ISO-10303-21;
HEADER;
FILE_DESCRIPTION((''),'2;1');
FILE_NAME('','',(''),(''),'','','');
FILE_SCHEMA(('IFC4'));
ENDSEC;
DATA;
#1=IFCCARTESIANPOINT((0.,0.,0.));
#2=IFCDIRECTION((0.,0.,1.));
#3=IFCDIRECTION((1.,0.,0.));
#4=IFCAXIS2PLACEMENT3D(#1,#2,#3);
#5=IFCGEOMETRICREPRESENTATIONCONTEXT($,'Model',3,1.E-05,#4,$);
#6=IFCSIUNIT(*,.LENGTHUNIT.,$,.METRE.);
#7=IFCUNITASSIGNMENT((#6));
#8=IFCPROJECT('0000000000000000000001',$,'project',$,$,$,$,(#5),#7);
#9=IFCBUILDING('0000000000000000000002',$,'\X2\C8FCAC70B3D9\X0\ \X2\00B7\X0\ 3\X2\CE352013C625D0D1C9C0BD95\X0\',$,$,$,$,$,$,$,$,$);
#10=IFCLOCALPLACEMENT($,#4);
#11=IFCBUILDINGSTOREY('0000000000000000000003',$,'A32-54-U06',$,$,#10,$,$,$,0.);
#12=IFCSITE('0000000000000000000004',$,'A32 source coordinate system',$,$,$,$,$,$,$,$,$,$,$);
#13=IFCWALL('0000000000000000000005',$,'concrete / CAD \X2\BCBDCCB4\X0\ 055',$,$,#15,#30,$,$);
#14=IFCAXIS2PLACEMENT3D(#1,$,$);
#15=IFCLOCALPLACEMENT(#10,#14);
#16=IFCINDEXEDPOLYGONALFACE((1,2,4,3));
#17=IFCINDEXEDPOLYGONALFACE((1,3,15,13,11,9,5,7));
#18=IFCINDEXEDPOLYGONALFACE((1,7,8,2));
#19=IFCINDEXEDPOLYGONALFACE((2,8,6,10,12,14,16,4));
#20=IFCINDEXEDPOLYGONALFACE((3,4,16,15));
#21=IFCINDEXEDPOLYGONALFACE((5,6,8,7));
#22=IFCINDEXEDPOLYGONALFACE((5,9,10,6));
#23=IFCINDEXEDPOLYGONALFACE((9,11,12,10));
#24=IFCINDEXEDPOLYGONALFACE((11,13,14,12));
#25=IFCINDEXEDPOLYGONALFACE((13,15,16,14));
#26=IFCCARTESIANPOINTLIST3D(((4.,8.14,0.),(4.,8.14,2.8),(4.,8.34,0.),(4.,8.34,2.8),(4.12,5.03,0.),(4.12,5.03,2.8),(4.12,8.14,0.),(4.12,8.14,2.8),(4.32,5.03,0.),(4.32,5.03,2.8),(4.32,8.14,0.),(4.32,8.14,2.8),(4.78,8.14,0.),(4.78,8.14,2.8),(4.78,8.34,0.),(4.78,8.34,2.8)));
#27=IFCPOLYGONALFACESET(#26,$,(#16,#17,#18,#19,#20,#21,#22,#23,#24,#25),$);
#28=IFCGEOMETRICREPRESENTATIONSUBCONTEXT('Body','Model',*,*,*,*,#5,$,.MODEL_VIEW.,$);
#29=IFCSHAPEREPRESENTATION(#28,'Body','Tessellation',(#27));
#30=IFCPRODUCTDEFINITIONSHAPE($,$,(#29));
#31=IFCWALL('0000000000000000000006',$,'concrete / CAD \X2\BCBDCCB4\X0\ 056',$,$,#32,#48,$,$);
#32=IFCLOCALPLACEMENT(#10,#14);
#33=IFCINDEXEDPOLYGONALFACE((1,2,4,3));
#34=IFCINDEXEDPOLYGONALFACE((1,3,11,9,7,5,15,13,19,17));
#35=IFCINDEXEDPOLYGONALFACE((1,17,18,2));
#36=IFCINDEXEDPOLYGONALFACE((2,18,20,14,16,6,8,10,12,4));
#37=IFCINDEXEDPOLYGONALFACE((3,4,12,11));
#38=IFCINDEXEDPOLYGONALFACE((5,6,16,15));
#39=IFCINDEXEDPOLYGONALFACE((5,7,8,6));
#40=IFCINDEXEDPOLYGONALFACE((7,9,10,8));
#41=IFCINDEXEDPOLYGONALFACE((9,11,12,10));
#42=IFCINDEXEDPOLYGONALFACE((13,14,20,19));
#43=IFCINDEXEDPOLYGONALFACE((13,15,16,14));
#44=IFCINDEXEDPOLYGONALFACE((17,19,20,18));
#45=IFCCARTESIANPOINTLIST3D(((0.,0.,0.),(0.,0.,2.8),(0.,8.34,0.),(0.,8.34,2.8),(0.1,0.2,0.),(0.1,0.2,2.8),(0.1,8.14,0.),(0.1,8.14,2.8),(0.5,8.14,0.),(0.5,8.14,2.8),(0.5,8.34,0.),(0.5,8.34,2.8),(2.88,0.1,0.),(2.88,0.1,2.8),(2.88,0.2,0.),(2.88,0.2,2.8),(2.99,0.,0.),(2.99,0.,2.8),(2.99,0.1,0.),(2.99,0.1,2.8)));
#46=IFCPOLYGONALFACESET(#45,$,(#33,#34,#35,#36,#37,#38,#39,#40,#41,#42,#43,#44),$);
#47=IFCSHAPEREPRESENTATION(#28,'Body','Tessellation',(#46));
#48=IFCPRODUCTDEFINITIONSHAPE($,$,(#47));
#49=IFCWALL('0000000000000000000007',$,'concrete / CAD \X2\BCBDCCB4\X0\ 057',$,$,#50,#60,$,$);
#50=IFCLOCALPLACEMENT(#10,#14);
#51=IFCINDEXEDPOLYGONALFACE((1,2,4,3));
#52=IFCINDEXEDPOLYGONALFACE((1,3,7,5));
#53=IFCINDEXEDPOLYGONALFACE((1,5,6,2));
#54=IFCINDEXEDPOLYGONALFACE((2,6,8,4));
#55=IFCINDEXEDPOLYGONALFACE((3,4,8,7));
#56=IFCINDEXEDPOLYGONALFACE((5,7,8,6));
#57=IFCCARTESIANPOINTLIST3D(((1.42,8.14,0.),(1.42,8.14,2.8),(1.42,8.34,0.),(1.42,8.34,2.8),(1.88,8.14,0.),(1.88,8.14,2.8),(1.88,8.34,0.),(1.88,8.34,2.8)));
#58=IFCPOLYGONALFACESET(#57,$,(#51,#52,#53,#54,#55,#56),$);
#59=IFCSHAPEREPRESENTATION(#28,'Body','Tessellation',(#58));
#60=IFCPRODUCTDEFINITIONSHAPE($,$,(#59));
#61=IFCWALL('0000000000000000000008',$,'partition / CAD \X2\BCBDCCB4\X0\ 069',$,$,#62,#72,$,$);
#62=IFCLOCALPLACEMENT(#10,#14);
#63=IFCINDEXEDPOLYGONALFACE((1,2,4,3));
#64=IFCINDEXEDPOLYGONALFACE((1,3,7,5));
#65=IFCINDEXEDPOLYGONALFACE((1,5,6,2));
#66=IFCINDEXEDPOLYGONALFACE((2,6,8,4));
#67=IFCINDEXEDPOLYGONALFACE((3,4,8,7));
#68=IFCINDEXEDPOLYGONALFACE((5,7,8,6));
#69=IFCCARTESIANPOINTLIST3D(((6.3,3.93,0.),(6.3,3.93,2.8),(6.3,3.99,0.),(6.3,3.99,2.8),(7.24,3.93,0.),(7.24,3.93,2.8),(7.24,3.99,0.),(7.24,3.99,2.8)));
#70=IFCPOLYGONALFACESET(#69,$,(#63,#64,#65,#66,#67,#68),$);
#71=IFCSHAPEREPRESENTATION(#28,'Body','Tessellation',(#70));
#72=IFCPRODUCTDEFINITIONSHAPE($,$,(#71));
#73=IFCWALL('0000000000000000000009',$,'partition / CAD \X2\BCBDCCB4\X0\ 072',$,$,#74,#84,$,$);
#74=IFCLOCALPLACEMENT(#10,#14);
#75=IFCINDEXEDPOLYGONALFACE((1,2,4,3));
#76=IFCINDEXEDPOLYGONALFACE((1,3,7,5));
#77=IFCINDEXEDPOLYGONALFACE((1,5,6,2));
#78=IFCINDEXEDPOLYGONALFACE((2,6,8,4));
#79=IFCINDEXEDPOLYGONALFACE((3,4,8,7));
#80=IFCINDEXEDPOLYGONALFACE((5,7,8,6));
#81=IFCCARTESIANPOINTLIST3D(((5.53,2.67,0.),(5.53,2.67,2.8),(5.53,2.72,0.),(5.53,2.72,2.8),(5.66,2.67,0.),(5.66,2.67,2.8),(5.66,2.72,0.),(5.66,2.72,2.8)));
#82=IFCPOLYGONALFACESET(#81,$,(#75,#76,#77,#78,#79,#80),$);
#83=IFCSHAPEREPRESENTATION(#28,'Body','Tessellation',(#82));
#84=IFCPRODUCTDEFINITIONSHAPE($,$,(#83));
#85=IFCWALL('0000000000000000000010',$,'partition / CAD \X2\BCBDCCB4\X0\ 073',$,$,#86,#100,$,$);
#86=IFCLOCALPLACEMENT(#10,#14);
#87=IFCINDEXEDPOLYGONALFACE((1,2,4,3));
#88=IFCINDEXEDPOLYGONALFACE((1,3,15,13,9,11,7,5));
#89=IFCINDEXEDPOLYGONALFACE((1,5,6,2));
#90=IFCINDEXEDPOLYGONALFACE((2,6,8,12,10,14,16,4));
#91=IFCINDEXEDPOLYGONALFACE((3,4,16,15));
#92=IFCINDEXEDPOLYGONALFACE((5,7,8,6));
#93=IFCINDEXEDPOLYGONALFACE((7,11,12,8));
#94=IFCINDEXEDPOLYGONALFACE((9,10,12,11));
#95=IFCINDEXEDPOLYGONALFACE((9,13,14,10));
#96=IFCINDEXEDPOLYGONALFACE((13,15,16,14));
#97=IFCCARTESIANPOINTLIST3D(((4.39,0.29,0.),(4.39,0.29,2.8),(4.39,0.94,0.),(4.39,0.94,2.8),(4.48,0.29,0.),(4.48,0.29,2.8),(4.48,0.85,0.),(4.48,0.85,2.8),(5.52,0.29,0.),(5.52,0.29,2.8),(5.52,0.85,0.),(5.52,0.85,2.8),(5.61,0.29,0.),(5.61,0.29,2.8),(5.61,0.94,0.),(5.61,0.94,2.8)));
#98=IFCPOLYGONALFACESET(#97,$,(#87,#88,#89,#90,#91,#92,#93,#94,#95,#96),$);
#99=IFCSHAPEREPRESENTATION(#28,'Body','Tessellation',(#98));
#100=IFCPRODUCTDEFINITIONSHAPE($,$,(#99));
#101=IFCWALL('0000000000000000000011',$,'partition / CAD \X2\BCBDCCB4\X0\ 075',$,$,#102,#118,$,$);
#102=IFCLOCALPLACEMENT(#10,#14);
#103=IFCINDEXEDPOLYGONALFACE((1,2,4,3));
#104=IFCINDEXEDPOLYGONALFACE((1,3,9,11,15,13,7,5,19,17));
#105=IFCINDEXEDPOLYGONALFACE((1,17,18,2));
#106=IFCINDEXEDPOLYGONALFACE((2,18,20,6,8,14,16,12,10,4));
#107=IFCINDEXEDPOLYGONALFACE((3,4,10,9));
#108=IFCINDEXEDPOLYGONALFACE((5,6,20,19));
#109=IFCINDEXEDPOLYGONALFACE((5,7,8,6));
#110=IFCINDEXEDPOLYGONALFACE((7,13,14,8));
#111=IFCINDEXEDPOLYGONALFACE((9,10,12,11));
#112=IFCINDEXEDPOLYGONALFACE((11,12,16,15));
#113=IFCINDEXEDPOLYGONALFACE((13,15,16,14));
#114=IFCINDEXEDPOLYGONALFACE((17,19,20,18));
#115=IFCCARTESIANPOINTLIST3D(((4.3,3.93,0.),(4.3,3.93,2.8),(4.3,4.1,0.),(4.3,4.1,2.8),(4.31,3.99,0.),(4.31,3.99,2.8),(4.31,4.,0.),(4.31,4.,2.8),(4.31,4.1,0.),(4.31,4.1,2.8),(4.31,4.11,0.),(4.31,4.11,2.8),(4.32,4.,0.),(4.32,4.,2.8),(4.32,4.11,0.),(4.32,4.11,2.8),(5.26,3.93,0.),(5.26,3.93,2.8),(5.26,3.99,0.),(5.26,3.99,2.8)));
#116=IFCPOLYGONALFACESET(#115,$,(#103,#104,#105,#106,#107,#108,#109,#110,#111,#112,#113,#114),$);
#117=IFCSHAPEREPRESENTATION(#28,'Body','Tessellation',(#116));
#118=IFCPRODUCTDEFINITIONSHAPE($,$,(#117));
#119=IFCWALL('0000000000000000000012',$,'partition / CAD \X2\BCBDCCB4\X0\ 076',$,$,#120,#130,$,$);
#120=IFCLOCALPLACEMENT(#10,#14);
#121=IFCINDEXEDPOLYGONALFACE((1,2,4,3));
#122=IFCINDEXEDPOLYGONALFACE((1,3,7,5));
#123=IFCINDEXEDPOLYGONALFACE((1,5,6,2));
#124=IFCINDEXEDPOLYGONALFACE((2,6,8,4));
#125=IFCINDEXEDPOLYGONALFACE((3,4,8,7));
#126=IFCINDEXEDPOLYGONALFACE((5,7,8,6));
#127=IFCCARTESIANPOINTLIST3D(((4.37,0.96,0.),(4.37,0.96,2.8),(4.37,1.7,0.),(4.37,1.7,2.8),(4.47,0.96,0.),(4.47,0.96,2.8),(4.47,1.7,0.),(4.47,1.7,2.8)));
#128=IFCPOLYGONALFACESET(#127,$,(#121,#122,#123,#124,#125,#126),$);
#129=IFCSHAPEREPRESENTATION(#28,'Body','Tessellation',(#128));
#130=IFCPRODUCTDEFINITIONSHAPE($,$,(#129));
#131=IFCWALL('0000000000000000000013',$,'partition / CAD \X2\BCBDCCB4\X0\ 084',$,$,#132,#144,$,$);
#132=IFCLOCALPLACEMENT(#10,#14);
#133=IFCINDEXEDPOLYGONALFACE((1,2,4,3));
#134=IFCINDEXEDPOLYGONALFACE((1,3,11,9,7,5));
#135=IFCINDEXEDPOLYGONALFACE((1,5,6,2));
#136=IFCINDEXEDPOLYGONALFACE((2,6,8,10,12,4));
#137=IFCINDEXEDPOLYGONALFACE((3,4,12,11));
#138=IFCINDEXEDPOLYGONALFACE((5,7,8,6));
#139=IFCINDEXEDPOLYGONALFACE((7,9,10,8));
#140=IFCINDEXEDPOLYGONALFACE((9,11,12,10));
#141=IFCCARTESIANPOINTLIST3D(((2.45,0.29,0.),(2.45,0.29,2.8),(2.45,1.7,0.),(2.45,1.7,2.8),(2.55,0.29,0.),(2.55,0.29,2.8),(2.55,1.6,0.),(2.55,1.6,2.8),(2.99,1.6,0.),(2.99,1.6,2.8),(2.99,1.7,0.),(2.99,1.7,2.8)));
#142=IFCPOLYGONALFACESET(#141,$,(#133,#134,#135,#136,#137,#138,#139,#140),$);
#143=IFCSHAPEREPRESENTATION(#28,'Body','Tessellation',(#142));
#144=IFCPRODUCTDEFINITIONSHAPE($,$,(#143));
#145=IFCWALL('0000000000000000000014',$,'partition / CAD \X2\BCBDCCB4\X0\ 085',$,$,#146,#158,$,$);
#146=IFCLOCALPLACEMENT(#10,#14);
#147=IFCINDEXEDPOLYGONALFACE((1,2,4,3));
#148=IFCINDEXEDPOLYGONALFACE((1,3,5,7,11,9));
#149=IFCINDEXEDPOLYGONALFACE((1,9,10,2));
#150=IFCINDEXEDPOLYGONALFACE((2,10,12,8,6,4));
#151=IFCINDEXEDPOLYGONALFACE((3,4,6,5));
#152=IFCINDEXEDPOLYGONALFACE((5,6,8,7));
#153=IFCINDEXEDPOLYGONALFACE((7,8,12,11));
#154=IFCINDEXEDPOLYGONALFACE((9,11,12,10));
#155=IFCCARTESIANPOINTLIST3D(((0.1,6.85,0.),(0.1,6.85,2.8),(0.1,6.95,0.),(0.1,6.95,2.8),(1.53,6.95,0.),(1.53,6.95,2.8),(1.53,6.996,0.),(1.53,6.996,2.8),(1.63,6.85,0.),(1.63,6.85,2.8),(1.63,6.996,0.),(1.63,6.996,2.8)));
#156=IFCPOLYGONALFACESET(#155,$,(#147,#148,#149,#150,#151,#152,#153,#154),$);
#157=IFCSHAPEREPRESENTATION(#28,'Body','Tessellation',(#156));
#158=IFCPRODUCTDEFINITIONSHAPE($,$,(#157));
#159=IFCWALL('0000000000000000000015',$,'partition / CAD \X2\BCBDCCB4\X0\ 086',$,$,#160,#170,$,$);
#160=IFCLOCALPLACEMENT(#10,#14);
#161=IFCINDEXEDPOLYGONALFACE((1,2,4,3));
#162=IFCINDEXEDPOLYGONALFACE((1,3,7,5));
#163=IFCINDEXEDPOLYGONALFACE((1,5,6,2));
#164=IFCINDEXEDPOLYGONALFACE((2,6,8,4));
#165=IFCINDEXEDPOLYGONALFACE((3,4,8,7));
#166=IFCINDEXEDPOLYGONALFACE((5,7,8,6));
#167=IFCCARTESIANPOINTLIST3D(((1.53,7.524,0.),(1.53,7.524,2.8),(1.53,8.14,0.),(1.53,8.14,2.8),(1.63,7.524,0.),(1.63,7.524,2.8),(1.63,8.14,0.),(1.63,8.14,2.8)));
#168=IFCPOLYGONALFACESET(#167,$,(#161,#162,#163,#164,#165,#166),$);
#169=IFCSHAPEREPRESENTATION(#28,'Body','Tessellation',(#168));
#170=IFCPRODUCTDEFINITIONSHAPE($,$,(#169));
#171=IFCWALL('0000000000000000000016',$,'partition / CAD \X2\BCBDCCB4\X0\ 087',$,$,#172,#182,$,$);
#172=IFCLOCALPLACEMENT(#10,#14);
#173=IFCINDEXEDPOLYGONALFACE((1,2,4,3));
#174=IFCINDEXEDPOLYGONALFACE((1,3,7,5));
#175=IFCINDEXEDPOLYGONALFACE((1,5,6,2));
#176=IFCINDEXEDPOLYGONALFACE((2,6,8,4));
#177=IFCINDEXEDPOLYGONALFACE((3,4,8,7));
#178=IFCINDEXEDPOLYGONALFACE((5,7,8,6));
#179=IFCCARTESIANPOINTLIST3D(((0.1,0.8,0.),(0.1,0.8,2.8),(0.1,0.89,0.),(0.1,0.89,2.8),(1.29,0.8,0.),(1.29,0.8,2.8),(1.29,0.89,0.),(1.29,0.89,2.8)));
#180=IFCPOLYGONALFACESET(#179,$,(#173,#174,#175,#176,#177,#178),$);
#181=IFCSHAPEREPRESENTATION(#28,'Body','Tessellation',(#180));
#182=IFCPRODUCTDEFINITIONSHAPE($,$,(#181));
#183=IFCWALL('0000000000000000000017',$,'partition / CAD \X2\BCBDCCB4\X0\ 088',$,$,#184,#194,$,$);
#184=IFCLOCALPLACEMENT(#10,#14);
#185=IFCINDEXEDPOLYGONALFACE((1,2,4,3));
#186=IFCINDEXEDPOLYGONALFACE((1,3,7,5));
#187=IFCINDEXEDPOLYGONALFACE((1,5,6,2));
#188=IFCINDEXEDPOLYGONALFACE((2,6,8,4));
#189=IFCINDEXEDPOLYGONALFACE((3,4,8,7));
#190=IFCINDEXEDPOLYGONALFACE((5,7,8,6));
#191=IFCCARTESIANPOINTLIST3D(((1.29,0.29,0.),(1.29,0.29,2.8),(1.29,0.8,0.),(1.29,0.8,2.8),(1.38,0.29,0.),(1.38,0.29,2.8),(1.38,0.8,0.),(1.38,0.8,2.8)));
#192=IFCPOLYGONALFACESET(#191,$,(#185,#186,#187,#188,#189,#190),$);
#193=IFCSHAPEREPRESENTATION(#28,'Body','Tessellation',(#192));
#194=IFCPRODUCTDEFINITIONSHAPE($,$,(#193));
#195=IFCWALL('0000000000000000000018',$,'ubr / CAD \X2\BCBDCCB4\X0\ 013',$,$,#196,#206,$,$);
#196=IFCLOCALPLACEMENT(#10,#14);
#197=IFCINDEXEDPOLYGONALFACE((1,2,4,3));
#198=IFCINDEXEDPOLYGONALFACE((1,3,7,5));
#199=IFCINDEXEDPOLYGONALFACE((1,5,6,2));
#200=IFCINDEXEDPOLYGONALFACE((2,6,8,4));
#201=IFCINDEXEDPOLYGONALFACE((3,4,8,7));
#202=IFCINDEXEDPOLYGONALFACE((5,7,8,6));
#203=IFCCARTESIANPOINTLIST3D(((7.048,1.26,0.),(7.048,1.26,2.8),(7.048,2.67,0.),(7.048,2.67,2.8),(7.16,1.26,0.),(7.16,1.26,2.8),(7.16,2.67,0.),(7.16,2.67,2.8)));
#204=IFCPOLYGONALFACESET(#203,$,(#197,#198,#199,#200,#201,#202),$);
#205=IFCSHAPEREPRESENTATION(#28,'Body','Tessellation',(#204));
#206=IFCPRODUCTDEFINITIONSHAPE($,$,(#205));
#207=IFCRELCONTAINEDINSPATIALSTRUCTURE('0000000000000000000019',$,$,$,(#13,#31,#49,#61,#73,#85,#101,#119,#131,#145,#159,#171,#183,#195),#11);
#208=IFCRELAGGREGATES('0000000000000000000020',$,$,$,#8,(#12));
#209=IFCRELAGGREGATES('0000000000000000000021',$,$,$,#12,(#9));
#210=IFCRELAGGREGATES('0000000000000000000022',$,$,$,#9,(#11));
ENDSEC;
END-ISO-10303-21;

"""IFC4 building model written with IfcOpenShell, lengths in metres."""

from ifc_helpers import new_model, si_unit, origin, origin_with_axes, place, context, subcontext, project, spatial, polyline, outline, extrude, element, save


model = new_model("IFC4")

# Units and contexts
model_context = context("Model", 3, precision=1e-05, world=origin_with_axes())
body_context = subcontext(model_context, "Body", "Model", "MODEL_VIEW")
ifc_project = project(units=[si_unit("LENGTHUNIT", "METRE")], contexts=[model_context])

# Site, building, storey
site = spatial("IfcSite", under=ifc_project, Name="A32 source coordinate system")
building = spatial("IfcBuilding", under=site, Name="주거동 · 3층–옥탑지붕")
storey_placement = place(None, origin_with_axes())
storey = spatial("IfcBuildingStorey", under=building, at=storey_placement, Name="A32-54-U06", Elevation=0.0)

# Walls
wall_1_placement = place(storey_placement, origin_with_axes())
element("IfcWall", 1, at=wall_1_placement, inside=storey, Name="concrete / CAD 벽체 055", context=body_context, shape_type="SweptSolid", body=[
    extrude(outline(polyline([(4.32, 5.03), (4.12, 5.03), (4.12, 8.14), (4.0, 8.14), (4.0, 8.34), (4.78, 8.34), (4.78, 8.14), (4.32, 8.14), (4.32, 5.03)])), origin(), (0.0, 0.0, 1.0), 2.8),
])
wall_2_placement = place(storey_placement, origin_with_axes())
element("IfcWall", 2, at=wall_2_placement, inside=storey, Name="concrete / CAD 벽체 056", context=body_context, shape_type="SweptSolid", body=[
    extrude(outline(polyline([(0.1, 8.14), (0.1, 0.2), (2.88, 0.2), (2.88, 0.1), (2.99, 0.1), (2.99, 0.0), (0.0, 0.0), (0.0, 8.34), (-0.35, 8.34), (-0.35, 8.34), (0.5, 8.34), (0.5, 8.14), (0.1, 8.14)])), origin(), (0.0, 0.0, 1.0), 2.8),
])
wall_3_placement = place(storey_placement, origin_with_axes())
element("IfcWall", 3, at=wall_3_placement, inside=storey, Name="concrete / CAD 벽체 057", context=body_context, shape_type="SweptSolid", body=[
    extrude(outline(polyline([(1.42, 8.14), (1.42, 8.34), (1.88, 8.34), (1.88, 8.14), (1.42, 8.14)])), origin(), (0.0, 0.0, 1.0), 2.8),
])
wall_4_placement = place(storey_placement, origin_with_axes())
element("IfcWall", 4, at=wall_4_placement, inside=storey, Name="partition / CAD 벽체 069", context=body_context, shape_type="SweptSolid", body=[
    extrude(outline(polyline([(7.24, 3.93), (6.3, 3.93), (6.3, 3.99), (7.24, 3.99), (7.24, 3.93)])), origin(), (0.0, 0.0, 1.0), 2.8),
])
wall_5_placement = place(storey_placement, origin_with_axes())
element("IfcWall", 5, at=wall_5_placement, inside=storey, Name="partition / CAD 벽체 072", context=body_context, shape_type="SweptSolid", body=[
    extrude(outline(polyline([(5.66, 2.67), (5.53, 2.67), (5.53, 2.72), (5.66, 2.72), (5.66, 2.67)])), origin(), (0.0, 0.0, 1.0), 2.8),
])
wall_6_placement = place(storey_placement, origin_with_axes())
element("IfcWall", 6, at=wall_6_placement, inside=storey, Name="partition / CAD 벽체 073", context=body_context, shape_type="SweptSolid", body=[
    extrude(outline(polyline([(4.48, 0.29), (4.39, 0.29), (4.39, 0.94), (5.61, 0.94), (5.61, 0.29), (5.52, 0.29), (5.52, 0.85), (4.48, 0.85), (4.48, 0.29)])), origin(), (0.0, 0.0, 1.0), 2.8),
])
wall_7_placement = place(storey_placement, origin_with_axes())
element("IfcWall", 7, at=wall_7_placement, inside=storey, Name="partition / CAD 벽체 075", context=body_context, shape_type="SweptSolid", body=[
    extrude(outline(polyline([(4.32, 4.0), (4.31, 4.0), (4.31, 3.99), (5.26, 3.99), (5.26, 3.93), (4.3, 3.93), (4.3, 4.1), (4.31, 4.1), (4.31, 4.11), (4.32, 4.11), (4.32, 4.0)])), origin(), (0.0, 0.0, 1.0), 2.8),
])
wall_8_placement = place(storey_placement, origin_with_axes())
element("IfcWall", 8, at=wall_8_placement, inside=storey, Name="partition / CAD 벽체 076", context=body_context, shape_type="SweptSolid", body=[
    extrude(outline(polyline([(4.37, 1.7), (4.47, 1.7), (4.47, 0.96), (4.37, 0.96), (4.37, 1.7)])), origin(), (0.0, 0.0, 1.0), 2.8),
])
wall_9_placement = place(storey_placement, origin_with_axes())
element("IfcWall", 9, at=wall_9_placement, inside=storey, Name="partition / CAD 벽체 084", context=body_context, shape_type="SweptSolid", body=[
    extrude(outline(polyline([(2.99, 1.6), (2.55, 1.6), (2.55, 0.29), (2.45, 0.29), (2.45, 1.7), (2.99, 1.7), (2.99, 1.6)])), origin(), (0.0, 0.0, 1.0), 2.8),
])
wall_10_placement = place(storey_placement, origin_with_axes())
element("IfcWall", 10, at=wall_10_placement, inside=storey, Name="partition / CAD 벽체 085", context=body_context, shape_type="SweptSolid", body=[
    extrude(outline(polyline([(1.63, 6.85), (0.1, 6.85), (0.1, 6.95), (1.53, 6.95), (1.53, 6.996), (1.63, 6.996), (1.63, 6.85)])), origin(), (0.0, 0.0, 1.0), 2.8),
])
wall_11_placement = place(storey_placement, origin_with_axes())
element("IfcWall", 11, at=wall_11_placement, inside=storey, Name="partition / CAD 벽체 086", context=body_context, shape_type="SweptSolid", body=[
    extrude(outline(polyline([(1.53, 7.524), (1.53, 8.14), (1.63, 8.14), (1.63, 7.524), (1.53, 7.524)])), origin(), (0.0, 0.0, 1.0), 2.8),
])
wall_12_placement = place(storey_placement, origin_with_axes())
element("IfcWall", 12, at=wall_12_placement, inside=storey, Name="partition / CAD 벽체 087", context=body_context, shape_type="SweptSolid", body=[
    extrude(outline(polyline([(1.29, 0.8), (0.1, 0.8), (0.1, 0.89), (1.29, 0.89), (1.29, 0.8)])), origin(), (0.0, 0.0, 1.0), 2.8),
])
wall_13_placement = place(storey_placement, origin_with_axes())
element("IfcWall", 13, at=wall_13_placement, inside=storey, Name="partition / CAD 벽체 088", context=body_context, shape_type="SweptSolid", body=[
    extrude(outline(polyline([(1.29, 0.29), (1.29, 0.8), (1.38, 0.8), (1.38, 0.29), (1.29, 0.29)])), origin(), (0.0, 0.0, 1.0), 2.8),
])
wall_14_placement = place(storey_placement, origin_with_axes())
element("IfcWall", 14, at=wall_14_placement, inside=storey, Name="ubr / CAD 벽체 013", context=body_context, shape_type="SweptSolid", body=[
    extrude(outline(polyline([(7.16, 1.26), (7.048, 1.26), (7.048, 2.67), (7.16, 2.67), (7.16, 1.26)])), origin(), (0.0, 0.0, 1.0), 2.8),
])

save(model, "model.ifc")
